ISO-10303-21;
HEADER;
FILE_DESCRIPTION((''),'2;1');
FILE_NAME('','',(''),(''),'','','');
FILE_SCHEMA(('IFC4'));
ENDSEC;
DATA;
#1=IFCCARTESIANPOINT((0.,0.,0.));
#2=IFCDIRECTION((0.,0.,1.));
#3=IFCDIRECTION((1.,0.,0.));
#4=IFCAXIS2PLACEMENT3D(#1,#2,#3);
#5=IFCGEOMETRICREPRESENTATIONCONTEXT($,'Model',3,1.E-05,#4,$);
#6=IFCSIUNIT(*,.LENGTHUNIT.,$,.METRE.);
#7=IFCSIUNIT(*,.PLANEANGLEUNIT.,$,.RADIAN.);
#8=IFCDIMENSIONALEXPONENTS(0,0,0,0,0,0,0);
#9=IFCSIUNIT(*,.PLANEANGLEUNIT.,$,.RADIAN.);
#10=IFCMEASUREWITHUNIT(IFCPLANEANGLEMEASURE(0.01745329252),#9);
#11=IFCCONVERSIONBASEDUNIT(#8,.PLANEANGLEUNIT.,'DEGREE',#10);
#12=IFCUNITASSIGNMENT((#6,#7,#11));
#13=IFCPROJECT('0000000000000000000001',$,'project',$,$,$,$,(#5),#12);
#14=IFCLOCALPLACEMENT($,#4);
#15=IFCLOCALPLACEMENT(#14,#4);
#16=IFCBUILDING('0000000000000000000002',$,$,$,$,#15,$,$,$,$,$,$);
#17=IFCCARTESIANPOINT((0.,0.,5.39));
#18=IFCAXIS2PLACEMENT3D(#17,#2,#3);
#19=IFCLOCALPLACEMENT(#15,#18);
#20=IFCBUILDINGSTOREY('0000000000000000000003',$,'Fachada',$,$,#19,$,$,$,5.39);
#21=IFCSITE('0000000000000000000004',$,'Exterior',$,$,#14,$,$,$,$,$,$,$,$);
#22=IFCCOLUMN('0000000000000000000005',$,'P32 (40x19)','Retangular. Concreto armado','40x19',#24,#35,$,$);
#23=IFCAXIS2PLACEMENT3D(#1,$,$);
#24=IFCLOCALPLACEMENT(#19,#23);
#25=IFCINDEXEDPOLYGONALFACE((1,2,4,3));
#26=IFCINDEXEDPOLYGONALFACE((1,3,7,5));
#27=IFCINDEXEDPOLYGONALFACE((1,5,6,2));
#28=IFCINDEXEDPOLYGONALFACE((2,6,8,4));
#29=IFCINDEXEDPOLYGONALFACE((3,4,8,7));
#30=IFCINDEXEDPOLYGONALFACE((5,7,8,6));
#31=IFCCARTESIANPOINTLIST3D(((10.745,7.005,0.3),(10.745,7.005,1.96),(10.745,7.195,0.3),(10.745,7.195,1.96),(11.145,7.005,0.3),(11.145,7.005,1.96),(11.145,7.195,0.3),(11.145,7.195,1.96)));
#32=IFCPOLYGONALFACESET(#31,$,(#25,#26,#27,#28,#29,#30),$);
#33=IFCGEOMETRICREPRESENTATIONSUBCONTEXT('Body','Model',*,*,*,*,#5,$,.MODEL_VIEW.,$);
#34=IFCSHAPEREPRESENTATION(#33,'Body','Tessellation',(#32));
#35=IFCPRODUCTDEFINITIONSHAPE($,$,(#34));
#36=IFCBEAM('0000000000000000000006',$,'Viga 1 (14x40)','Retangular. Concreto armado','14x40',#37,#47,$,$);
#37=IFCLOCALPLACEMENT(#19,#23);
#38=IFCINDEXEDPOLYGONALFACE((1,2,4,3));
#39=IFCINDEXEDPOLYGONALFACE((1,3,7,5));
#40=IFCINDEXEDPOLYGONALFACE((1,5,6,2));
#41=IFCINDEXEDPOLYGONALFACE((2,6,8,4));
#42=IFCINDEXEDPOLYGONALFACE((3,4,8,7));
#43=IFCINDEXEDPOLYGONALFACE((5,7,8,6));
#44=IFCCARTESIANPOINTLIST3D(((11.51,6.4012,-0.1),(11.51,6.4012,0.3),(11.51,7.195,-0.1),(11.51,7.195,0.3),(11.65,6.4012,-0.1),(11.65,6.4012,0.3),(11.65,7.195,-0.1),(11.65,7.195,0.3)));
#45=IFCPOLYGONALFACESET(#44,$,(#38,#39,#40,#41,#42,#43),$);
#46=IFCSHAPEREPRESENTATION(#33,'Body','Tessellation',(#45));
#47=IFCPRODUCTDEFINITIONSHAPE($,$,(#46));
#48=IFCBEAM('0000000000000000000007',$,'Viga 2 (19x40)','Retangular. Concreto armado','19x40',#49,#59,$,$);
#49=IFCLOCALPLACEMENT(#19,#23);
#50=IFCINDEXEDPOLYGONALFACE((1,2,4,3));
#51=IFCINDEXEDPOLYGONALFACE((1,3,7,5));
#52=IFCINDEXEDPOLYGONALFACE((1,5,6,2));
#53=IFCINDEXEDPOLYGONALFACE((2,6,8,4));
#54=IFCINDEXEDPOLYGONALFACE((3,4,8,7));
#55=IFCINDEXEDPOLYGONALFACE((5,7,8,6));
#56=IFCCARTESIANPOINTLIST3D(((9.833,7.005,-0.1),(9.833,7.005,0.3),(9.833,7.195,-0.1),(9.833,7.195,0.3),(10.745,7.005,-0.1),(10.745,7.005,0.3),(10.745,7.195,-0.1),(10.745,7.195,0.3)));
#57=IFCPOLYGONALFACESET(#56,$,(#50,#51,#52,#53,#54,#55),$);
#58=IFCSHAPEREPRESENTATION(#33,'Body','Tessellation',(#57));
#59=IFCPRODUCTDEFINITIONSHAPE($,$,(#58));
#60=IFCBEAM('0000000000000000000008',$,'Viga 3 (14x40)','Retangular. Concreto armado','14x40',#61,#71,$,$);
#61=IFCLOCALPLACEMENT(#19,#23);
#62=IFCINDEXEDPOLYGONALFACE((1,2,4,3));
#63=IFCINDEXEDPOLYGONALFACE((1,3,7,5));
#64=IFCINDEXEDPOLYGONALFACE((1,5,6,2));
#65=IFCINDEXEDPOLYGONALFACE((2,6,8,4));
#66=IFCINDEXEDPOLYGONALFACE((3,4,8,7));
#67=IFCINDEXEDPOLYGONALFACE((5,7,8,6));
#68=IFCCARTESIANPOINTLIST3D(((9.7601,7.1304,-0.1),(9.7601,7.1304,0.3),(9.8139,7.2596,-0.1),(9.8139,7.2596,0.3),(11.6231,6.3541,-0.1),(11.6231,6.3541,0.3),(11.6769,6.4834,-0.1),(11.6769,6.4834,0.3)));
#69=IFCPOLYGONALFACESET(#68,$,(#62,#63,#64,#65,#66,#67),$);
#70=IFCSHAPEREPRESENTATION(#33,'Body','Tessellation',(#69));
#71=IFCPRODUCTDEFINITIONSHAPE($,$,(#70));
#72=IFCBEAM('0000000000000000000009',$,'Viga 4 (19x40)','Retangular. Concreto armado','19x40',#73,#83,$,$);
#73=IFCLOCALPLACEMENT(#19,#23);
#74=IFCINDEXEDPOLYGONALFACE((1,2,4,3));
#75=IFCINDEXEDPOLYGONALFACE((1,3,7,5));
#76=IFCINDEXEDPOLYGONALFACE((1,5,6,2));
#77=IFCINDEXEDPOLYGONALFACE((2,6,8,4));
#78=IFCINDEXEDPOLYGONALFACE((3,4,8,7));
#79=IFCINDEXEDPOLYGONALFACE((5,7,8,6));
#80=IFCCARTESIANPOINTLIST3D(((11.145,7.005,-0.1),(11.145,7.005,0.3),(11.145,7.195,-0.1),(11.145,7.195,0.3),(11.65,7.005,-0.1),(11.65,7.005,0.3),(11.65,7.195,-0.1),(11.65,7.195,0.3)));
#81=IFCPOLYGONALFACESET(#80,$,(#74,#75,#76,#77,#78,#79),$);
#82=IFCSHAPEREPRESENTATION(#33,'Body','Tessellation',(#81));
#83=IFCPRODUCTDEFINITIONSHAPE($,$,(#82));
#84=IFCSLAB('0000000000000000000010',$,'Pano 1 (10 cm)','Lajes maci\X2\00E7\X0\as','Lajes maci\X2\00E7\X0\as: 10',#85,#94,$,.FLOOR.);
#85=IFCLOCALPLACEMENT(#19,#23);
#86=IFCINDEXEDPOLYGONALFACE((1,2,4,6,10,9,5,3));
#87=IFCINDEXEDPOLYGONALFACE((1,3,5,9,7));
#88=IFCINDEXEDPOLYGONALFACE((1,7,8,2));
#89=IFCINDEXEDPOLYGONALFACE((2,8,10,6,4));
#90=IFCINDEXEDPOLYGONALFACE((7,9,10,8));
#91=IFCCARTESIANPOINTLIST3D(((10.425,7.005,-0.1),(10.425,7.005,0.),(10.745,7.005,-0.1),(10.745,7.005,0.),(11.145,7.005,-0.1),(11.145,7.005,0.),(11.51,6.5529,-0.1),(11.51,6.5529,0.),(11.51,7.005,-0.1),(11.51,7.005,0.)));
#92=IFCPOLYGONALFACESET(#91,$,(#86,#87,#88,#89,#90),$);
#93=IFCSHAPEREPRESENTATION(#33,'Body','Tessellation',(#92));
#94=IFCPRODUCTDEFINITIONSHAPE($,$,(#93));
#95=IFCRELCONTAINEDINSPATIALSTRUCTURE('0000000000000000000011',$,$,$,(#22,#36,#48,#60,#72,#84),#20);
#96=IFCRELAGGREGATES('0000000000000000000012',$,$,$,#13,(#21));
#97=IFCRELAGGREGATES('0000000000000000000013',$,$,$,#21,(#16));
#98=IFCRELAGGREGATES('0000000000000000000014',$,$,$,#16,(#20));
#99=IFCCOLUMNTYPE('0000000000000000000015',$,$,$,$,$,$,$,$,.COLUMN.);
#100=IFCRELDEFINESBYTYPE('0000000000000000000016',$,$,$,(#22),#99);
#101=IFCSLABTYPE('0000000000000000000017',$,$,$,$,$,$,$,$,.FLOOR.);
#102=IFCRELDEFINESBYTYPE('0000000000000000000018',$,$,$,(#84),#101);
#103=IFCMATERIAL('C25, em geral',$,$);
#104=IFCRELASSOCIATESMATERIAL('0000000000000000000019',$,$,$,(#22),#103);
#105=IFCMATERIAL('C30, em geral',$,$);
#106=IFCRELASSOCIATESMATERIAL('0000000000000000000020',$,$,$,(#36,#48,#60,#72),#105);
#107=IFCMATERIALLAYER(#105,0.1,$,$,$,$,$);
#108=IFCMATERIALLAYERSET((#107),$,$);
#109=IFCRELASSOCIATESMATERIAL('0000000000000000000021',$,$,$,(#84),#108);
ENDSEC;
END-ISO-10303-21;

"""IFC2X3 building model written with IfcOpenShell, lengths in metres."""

from ifc_helpers import new_model, entity, si_unit, converted_unit, frame, frame_2d, origin_with_axes, place, context, subcontext, project, spatial, polyline, rectangle, outline, extrude, material, layer, layer_set, layer_usage, type_object, element, save


model = new_model("IFC2X3")

# Units and contexts
model_context = context("Model", 3, precision=1e-05, world=origin_with_axes())
body_context = subcontext(model_context, "Body", "Model", "MODEL_VIEW")
ifc_project = project(units=[si_unit("LENGTHUNIT", "METRE"), si_unit("PLANEANGLEUNIT", "RADIAN"), converted_unit("PLANEANGLEUNIT", "DEGREE", entity("IfcPlaneAngleMeasure", 0.01745329252), si_unit("PLANEANGLEUNIT", "RADIAN"), dimensions=[0, 0, 0, 0, 0, 0, 0])], contexts=[model_context])

# Site, building, storey
site_placement = place(None, origin_with_axes())
site = spatial("IfcSite", under=ifc_project, at=site_placement, Name="Exterior")
building_placement = place(site_placement, origin_with_axes())
building = spatial("IfcBuilding", under=site, at=building_placement)
storey_placement = place(building_placement, frame((0.0, 0.0, 5.39), z_axis=(0.0, 0.0, 1.0), x_axis=(1.0, 0.0, 0.0)))
storey = spatial("IfcBuildingStorey", under=building, at=storey_placement, Name="Fachada", Elevation=5.39)

# Column
ifc_material_1 = material(Name="C25, em geral")
column_type = type_object("IfcColumnType", PredefinedType="COLUMN")
column_placement = place(storey_placement, frame((11.145, 7.005, 0.3), z_axis=(0.0, 0.0, 1.0), x_axis=(1.0, 0.0, 0.0)))
element("IfcColumn", 1, at=column_placement, inside=storey, type_object=column_type, material=ifc_material_1, Name="P32 (40x19)", Description="Retangular. Concreto armado", ObjectType="40x19", context=body_context, shape_type="SweptSolid", body=[
    extrude(rectangle(XDim=0.4, YDim=0.19, at=frame_2d((-0.2, 0.095), x_axis=(1.0, 0.0))), origin_with_axes(), (0.0, 0.0, 1.0), 1.66),
])

# Beams
ifc_material_2 = material(Name="C30, em geral")
beam_1_placement = place(storey_placement, frame((11.58, 7.195, 0.3), z_axis=(0.0, -1.0, 0.0), x_axis=(1.0, 0.0, 0.0)))
element("IfcBeam", 2, at=beam_1_placement, inside=storey, material=ifc_material_2, Name="Viga 1 (14x40)", Description="Retangular. Concreto armado", ObjectType="14x40", context=body_context, shape_type="SweptSolid", body=[
    extrude(rectangle(XDim=0.14, YDim=0.4, at=frame_2d((0.0, -0.2), x_axis=(1.0, 0.0))), origin_with_axes(), (0.0, 0.0, 1.0), 0.7937),
])
beam_2_placement = place(storey_placement, frame((9.833, 7.1, 0.3), z_axis=(1.0, 0.0, 0.0), x_axis=(0.0, 1.0, 0.0)))
element("IfcBeam", 3, at=beam_2_placement, inside=storey, material=ifc_material_2, Name="Viga 2 (19x40)", Description="Retangular. Concreto armado", ObjectType="19x40", context=body_context, shape_type="SweptSolid", body=[
    extrude(rectangle(XDim=0.19, YDim=0.4, at=frame_2d((0.0, -0.2), x_axis=(1.0, 0.0))), origin_with_axes(), (0.0, 0.0, 1.0), 0.912),
])
beam_3_placement = place(storey_placement, frame((9.787, 7.195, 0.3), z_axis=(0.923077, -0.384615, 0.0), x_axis=(0.384615, 0.923077, 0.0)))
element("IfcBeam", 4, at=beam_3_placement, inside=storey, material=ifc_material_2, Name="Viga 3 (14x40)", Description="Retangular. Concreto armado", ObjectType="14x40", context=body_context, shape_type="SweptSolid", body=[
    extrude(rectangle(XDim=0.14, YDim=0.4, at=frame_2d((0.0, -0.2), x_axis=(1.0, 0.0))), origin_with_axes(), (0.0, 0.0, 1.0), 2.0183),
])
beam_4_placement = place(storey_placement, frame((11.145, 7.1, 0.3), z_axis=(1.0, 0.0, 0.0), x_axis=(0.0, 1.0, 0.0)))
element("IfcBeam", 5, at=beam_4_placement, inside=storey, material=ifc_material_2, Name="Viga 4 (19x40)", Description="Retangular. Concreto armado", ObjectType="19x40", context=body_context, shape_type="SweptSolid", body=[
    extrude(rectangle(XDim=0.19, YDim=0.4, at=frame_2d((0.0, -0.2), x_axis=(1.0, 0.0))), origin_with_axes(), (0.0, 0.0, 1.0), 0.505),
])

# Slab
ifc_layer = layer(ifc_material_2, 0.1)
ifc_layer_set = layer_set([ifc_layer])
ifc_layer_usage = layer_usage(ifc_layer_set, "AXIS3", "POSITIVE", 0.0)
slab_type = type_object("IfcSlabType", PredefinedType="FLOOR")
slab_placement = place(storey_placement, frame((0.0, 0.0, -0.1), z_axis=(0.0, 0.0, 1.0), x_axis=(1.0, 0.0, 0.0)))
element("IfcSlab", 6, at=slab_placement, inside=storey, type_object=slab_type, material=ifc_layer_usage, Name="Pano 1 (10 cm)", Description="Lajes maciças", ObjectType="Lajes maciças: 10", PredefinedType="FLOOR", context=body_context, shape_type="SweptSolid", body=[
    extrude(outline(polyline([(11.145, 7.005), (10.745, 7.005), (10.425, 7.005), (11.51, 6.5529), (11.51, 7.005), (11.145, 7.005)])), origin_with_axes(), (0.0, 0.0, 1.0), 0.1),
])

save(model, "model.ifc")
